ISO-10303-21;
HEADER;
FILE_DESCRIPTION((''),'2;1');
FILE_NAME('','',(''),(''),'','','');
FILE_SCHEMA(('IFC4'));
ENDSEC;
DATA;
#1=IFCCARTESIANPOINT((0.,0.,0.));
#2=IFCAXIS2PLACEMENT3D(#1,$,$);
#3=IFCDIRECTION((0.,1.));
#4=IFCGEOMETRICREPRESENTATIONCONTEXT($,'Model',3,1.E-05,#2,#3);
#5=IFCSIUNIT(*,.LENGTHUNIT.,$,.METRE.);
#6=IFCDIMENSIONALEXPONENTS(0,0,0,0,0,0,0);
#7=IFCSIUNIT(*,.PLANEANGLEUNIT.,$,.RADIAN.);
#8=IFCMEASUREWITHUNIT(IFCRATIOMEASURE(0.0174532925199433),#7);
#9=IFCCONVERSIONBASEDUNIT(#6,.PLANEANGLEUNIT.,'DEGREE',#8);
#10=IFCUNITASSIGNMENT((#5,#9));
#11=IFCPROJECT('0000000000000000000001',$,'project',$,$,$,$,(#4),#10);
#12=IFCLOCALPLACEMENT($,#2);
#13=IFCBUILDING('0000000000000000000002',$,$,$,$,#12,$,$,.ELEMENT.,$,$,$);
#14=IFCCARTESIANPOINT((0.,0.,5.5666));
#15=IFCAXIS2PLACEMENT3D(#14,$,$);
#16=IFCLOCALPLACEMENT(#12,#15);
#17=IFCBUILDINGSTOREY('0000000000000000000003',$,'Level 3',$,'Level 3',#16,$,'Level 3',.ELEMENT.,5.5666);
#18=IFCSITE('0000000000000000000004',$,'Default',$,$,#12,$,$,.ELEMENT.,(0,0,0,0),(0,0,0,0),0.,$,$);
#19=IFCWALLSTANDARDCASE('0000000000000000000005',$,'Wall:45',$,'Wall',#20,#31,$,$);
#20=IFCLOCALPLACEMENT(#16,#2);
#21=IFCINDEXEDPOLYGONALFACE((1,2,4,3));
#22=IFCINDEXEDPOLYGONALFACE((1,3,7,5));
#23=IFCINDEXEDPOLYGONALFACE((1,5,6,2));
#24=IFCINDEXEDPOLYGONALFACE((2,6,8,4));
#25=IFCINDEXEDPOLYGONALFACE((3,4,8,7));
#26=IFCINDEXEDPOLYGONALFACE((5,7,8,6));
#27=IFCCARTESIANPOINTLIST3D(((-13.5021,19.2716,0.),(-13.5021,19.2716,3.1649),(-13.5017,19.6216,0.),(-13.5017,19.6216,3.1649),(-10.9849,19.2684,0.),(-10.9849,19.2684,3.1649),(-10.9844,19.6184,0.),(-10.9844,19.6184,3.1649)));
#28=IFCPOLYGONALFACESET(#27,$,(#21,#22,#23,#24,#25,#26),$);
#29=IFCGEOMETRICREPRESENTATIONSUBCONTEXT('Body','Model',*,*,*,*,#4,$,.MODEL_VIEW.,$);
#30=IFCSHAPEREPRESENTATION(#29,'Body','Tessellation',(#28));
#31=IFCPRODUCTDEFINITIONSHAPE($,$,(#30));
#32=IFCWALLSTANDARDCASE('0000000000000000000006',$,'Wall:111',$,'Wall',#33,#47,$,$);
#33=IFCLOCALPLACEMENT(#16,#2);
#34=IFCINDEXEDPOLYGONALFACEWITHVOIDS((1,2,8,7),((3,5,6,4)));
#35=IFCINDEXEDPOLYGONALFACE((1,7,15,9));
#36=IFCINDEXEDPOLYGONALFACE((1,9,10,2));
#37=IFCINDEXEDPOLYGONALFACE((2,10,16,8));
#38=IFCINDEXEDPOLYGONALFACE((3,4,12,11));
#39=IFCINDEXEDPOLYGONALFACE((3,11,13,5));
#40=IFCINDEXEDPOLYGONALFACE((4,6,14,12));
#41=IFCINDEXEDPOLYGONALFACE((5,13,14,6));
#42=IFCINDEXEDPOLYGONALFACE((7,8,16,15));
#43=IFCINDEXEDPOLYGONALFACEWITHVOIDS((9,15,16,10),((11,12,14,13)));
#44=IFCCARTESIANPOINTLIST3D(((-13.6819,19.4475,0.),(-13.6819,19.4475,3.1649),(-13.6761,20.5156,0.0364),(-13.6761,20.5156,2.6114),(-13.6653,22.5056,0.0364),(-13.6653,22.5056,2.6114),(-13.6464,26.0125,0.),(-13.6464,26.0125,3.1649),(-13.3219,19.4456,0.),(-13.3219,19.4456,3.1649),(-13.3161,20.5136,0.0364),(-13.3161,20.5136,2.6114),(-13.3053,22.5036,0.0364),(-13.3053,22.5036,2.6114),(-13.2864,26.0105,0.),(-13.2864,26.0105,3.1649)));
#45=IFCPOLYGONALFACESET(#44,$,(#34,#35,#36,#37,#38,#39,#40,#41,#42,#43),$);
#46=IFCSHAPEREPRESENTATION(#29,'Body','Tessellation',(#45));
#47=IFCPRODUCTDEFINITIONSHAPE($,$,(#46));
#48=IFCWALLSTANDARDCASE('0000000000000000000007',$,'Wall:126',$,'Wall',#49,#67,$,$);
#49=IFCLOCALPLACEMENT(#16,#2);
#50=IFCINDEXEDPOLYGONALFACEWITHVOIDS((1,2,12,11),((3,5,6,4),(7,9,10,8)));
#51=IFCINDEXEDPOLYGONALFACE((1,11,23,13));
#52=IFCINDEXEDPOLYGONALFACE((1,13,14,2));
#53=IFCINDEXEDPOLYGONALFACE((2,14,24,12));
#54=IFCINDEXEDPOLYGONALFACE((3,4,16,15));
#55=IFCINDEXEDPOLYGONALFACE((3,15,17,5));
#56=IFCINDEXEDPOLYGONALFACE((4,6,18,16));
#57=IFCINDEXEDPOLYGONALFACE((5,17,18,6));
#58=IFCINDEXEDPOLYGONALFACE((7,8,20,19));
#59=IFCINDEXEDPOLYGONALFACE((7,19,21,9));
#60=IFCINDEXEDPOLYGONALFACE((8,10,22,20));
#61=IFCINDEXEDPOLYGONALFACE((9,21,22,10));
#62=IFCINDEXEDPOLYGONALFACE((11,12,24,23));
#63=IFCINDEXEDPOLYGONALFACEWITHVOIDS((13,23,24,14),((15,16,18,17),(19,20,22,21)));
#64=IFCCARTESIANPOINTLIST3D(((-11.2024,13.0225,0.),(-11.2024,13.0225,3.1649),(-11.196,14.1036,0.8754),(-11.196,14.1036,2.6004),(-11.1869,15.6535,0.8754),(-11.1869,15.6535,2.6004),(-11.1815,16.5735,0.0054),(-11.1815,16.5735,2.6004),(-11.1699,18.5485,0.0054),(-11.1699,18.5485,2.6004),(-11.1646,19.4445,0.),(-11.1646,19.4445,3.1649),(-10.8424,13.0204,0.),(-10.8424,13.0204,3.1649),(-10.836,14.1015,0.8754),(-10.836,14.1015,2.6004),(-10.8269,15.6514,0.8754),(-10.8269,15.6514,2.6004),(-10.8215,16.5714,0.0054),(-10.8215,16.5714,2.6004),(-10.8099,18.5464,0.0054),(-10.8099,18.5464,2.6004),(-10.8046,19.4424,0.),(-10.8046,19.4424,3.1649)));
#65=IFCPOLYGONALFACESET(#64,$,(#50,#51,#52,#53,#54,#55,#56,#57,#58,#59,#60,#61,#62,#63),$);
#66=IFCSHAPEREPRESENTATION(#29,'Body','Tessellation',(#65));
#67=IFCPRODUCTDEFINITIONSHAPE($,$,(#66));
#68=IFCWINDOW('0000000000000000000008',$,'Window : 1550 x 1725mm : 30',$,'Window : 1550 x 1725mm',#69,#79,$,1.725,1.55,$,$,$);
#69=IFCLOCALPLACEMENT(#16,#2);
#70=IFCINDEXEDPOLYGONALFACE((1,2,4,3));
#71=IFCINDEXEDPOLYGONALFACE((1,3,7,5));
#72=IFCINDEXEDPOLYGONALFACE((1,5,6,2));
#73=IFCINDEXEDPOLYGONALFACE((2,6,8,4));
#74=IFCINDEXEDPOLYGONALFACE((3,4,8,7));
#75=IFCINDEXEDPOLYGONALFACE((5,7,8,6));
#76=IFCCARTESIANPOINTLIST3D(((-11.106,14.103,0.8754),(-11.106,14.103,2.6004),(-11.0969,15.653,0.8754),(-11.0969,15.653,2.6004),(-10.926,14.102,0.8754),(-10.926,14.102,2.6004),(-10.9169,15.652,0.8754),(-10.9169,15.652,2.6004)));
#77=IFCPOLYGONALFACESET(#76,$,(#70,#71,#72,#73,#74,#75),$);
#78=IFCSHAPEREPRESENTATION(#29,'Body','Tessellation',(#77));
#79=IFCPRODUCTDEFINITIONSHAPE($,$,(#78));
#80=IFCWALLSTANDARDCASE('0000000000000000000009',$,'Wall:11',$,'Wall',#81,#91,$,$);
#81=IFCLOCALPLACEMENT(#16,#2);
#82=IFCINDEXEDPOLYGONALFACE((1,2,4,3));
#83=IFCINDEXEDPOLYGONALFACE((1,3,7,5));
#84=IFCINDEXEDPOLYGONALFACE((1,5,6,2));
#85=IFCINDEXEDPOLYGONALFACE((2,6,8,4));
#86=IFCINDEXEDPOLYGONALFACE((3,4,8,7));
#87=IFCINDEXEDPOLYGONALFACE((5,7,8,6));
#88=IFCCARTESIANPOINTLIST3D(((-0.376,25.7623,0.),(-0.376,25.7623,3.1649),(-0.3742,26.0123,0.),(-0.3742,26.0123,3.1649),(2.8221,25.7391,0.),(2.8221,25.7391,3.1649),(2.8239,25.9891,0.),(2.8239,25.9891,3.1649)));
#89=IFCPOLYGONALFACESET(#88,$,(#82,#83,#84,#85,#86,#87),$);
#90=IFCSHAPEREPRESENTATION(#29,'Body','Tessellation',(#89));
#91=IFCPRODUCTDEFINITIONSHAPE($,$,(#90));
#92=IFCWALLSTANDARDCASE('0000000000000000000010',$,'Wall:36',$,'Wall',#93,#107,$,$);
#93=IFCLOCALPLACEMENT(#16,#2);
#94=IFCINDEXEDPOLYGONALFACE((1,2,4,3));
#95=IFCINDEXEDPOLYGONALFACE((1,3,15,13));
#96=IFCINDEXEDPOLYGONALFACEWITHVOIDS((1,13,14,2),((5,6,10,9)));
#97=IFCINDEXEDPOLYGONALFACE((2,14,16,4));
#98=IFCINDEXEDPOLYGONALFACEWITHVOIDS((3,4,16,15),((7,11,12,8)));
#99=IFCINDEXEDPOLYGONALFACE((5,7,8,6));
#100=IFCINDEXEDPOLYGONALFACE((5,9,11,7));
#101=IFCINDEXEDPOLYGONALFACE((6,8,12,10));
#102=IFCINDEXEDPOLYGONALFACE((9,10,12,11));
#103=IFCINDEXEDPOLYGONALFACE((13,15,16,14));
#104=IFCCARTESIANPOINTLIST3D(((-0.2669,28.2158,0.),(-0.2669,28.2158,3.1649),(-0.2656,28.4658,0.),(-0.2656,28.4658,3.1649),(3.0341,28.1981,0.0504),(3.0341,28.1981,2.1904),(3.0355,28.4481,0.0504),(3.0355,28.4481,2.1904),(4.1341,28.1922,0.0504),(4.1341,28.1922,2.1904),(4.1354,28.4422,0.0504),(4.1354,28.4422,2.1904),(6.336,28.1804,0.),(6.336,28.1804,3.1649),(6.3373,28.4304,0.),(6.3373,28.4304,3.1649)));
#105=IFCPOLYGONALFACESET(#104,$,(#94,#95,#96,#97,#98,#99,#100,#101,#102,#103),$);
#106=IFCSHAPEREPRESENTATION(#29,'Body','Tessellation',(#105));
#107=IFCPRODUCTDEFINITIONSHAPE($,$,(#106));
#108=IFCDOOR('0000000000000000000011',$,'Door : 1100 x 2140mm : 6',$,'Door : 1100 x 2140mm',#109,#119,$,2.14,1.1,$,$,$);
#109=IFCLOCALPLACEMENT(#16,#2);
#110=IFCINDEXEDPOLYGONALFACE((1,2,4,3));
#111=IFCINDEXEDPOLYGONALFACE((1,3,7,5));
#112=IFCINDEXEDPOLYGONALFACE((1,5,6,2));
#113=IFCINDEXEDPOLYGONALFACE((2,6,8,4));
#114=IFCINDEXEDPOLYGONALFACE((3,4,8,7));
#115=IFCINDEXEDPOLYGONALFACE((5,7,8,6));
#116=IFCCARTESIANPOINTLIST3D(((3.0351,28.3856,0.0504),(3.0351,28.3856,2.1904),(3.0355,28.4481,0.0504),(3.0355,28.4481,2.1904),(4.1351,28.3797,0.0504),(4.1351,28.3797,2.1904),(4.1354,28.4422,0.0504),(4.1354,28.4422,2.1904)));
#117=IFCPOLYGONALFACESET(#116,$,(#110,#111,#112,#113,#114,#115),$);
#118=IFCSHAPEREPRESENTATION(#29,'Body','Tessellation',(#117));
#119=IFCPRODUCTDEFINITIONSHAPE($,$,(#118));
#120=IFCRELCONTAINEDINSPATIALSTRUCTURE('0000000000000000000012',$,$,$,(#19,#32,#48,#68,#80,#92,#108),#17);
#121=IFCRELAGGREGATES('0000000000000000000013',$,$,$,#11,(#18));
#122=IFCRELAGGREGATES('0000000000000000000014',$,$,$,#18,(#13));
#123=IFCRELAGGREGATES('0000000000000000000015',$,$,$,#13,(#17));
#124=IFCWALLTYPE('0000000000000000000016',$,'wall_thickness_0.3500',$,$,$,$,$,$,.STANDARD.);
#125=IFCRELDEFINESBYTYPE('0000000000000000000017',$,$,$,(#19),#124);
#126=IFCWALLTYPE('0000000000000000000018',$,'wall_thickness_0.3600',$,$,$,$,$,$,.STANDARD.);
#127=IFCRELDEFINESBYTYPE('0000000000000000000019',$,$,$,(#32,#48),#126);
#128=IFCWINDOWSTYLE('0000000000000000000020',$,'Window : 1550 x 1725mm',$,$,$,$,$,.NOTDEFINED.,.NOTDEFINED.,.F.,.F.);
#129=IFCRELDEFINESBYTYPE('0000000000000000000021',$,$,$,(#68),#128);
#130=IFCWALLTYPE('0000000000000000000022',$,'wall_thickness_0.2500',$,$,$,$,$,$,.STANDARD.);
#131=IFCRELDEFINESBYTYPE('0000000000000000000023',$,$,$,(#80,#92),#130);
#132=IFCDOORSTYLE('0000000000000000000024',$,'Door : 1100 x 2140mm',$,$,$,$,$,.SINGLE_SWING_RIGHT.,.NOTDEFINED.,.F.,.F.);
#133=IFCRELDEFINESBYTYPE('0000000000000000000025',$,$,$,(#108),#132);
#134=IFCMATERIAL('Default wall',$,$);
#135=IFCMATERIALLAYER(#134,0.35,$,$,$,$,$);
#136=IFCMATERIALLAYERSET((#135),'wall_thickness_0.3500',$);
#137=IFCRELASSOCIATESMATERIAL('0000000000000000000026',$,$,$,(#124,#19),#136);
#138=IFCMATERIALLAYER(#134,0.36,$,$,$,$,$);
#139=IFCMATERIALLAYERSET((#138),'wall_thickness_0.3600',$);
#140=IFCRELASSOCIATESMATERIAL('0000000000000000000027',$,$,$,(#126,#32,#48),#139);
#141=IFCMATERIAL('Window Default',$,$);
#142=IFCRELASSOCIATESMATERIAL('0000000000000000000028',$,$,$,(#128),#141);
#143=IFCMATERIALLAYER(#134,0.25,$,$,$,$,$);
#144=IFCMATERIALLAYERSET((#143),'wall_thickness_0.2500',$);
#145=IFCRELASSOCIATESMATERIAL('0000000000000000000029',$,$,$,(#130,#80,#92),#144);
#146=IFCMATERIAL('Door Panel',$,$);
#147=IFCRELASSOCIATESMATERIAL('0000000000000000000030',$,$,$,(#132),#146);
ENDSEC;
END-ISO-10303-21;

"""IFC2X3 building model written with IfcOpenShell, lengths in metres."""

from ifc_helpers import new_model, entity, si_unit, converted_unit, direction, frame, frame_2d, origin, origin_2d_with_axis, place, context, subcontext, project, spatial, polyline, rectangle, outline, extrude, source, transform, mapped, material, layer, layer_set, layer_usage, type_object, type_shapes, element, fill, save


model = new_model("IFC2X3")

# Units and contexts
model_context = context("Model", 3, precision=1e-05, world=origin(), true_north=direction((0.0, 1.0)))
body_context = subcontext(model_context, "Body", "Model", "MODEL_VIEW")
ifc_project = project(units=[si_unit("LENGTHUNIT", "METRE"), converted_unit("PLANEANGLEUNIT", "DEGREE", entity("IfcRatioMeasure", 0.0174532925199433), si_unit("PLANEANGLEUNIT", "RADIAN"), dimensions=[0, 0, 0, 0, 0, 0, 0])], contexts=[model_context])

# Site, building, storey
placement_1 = place(None, origin())
site = spatial("IfcSite", under=ifc_project, at=placement_1, Name="Default", CompositionType="ELEMENT", RefLatitude=(0, 0, 0, 0), RefLongitude=(0, 0, 0, 0), RefElevation=0.0)
building = spatial("IfcBuilding", under=site, at=placement_1, CompositionType="ELEMENT")
storey_placement = place(placement_1, frame((0.0, 0.0, 5.5666)))
storey = spatial("IfcBuildingStorey", under=building, at=storey_placement, Name="Level 3", ObjectType="Level 3", LongName="Level 3", CompositionType="ELEMENT", Elevation=5.5666)

# Wall
ifc_material_1 = material(Name="Default wall")
ifc_layer_1 = layer(ifc_material_1, 0.35)
ifc_layer_set_1 = layer_set([ifc_layer_1], Name="wall_thickness_0.3500")
ifc_layer_usage_1 = layer_usage(ifc_layer_set_1, "AXIS2", "POSITIVE", -0.175)
wall_type_1 = type_object("IfcWallType", Name="wall_thickness_0.3500", PredefinedType="STANDARD", material=ifc_layer_set_1)
wall_1_placement = place(storey_placement, frame((-13.5019, 19.4466, 0.0), z_axis=(0.0, 0.0, 1.0), x_axis=(0.999999, -0.001234, 0.0)))
element("IfcWallStandardCase", 1, at=wall_1_placement, inside=storey, type_object=wall_type_1, material=ifc_layer_usage_1, Name="Wall:45", ObjectType="Wall", context=body_context, shape_type="SweptSolid", body=[
    extrude(outline(polyline([(2.5172, -0.175), (2.5172, 0.175), (0.0, 0.175), (0.0, -0.175), (2.5172, -0.175)])), origin(), (0.0, 0.0, 1.0), 3.1649),
])

# Wall, opening
ifc_layer_2 = layer(ifc_material_1, 0.36)
ifc_layer_set_2 = layer_set([ifc_layer_2], Name="wall_thickness_0.3600")
ifc_layer_usage_2 = layer_usage(ifc_layer_set_2, "AXIS2", "POSITIVE", -0.18)
wall_type_2 = type_object("IfcWallType", Name="wall_thickness_0.3600", PredefinedType="STANDARD", material=ifc_layer_set_2)
wall_2_placement = place(storey_placement, frame((-13.4664, 26.0115, 0.0), z_axis=(0.0, 0.0, 1.0), x_axis=(-0.005406, -0.999985, 0.0)))
wall_2 = element("IfcWallStandardCase", 2, at=wall_2_placement, inside=storey, type_object=wall_type_2, material=ifc_layer_usage_2, Name="Wall:111", ObjectType="Wall", context=body_context, shape_type="SweptSolid", body=[
    extrude(outline(polyline([(6.565, -0.18), (6.565, 0.18), (0.0, 0.18), (0.0, -0.18), (6.565, -0.18)])), origin(), (0.0, 0.0, 1.0), 3.1649),
])
opening_1_placement = place(wall_2_placement, frame((3.507, -0.18, 0.0364)))
element("IfcOpeningElement", 3, at=opening_1_placement, cuts=wall_2, ObjectType="Opening", context=body_context, shape_type="SweptSolid", body=[
    extrude(rectangle(XDim=1.99, YDim=2.575, at=frame_2d((1.2875, 0.995), x_axis=(0.0, 1.0))), frame((0.0, 0.0, 0.0), z_axis=(0.0, 1.0, 0.0), x_axis=(0.0, 0.0, 1.0)), (0.0, 0.0, 1.0), 0.36),
])

# Wall, openings, window
wall_3_placement = place(storey_placement, frame((-10.9846, 19.4435, 0.0), z_axis=(0.0, 0.0, 1.0), x_axis=(-0.005875, -0.999983, 0.0)))
wall_3 = element("IfcWallStandardCase", 4, at=wall_3_placement, inside=storey, type_object=wall_type_2, material=ifc_layer_usage_2, Name="Wall:126", ObjectType="Wall", context=body_context, shape_type="SweptSolid", body=[
    extrude(outline(polyline([(6.4221, -0.18), (6.4221, 0.18), (0.0, 0.18), (0.0, -0.18), (6.4221, -0.18)])), origin(), (0.0, 0.0, 1.0), 3.1649),
])
opening_2_placement = place(wall_3_placement, frame((0.896, -0.18, 0.0054)))
element("IfcOpeningElement", 5, at=opening_2_placement, cuts=wall_3, ObjectType="Opening", context=body_context, shape_type="SweptSolid", body=[
    extrude(rectangle(XDim=1.975, YDim=2.595, at=frame_2d((1.2975, 0.9875), x_axis=(0.0, 1.0))), frame((0.0, 0.0, 0.0), z_axis=(0.0, 1.0, 0.0), x_axis=(0.0, 0.0, 1.0)), (0.0, 0.0, 1.0), 0.36),
])
opening_3_placement = place(wall_3_placement, frame((3.791, -0.18, 0.8754)))
opening_3 = element("IfcOpeningElement", 6, at=opening_3_placement, cuts=wall_3, ObjectType="Opening", context=body_context, shape_type="SweptSolid", body=[
    extrude(rectangle(XDim=1.55, YDim=1.725, at=frame_2d((0.8625, 0.775), x_axis=(0.0, 1.0))), frame((0.0, 0.0, 0.0), z_axis=(0.0, 1.0, 0.0), x_axis=(0.0, 0.0, 1.0)), (0.0, 0.0, 1.0), 0.36),
])
ifc_material_2 = material(Name="Window Default")
window_style_1 = type_object("IfcWindowStyle", Name="Window : 1550 x 1725mm", ConstructionType="NOTDEFINED", OperationType="NOTDEFINED", ParameterTakesPrecedence=False, Sizeable=False, material=ifc_material_2)
shared_shape_1 = source(origin(), body_context, "Body", "SweptSolid", [
    extrude(rectangle(XDim=0.18, YDim=1.55, at=origin_2d_with_axis()), frame((0.775, 0.18, 0.0), z_axis=(0.0, 0.0, 1.0), x_axis=(0.0, 1.0, 0.0)), (0.0, 0.0, 1.0), 1.725),
])
type_shapes(window_style_1, [shared_shape_1])
window_1_placement = place(opening_3_placement, origin())
window_1 = element("IfcWindow", 7, at=window_1_placement, inside=storey, type_object=window_style_1, Name="Window : 1550 x 1725mm : 30", ObjectType="Window : 1550 x 1725mm", OverallHeight=1.725, OverallWidth=1.55, context=body_context, shape_type="MappedRepresentation", body=[
    mapped(shared_shape_1, transform((0.0, 0.0, 0.0), scale=1.0)),
])
fill(opening_3, window_1)

# Wall
ifc_layer_3 = layer(ifc_material_1, 0.25)
ifc_layer_set_3 = layer_set([ifc_layer_3], Name="wall_thickness_0.2500")
ifc_layer_usage_3 = layer_usage(ifc_layer_set_3, "AXIS2", "POSITIVE", -0.125)
wall_type_3 = type_object("IfcWallType", Name="wall_thickness_0.2500", PredefinedType="STANDARD", material=ifc_layer_set_3)
wall_4_placement = place(storey_placement, frame((-0.3751, 25.8873, 0.0), z_axis=(0.0, 0.0, 1.0), x_axis=(0.999974, -0.00727, 0.0)))
element("IfcWallStandardCase", 8, at=wall_4_placement, inside=storey, type_object=wall_type_3, material=ifc_layer_usage_3, Name="Wall:11", ObjectType="Wall", context=body_context, shape_type="SweptSolid", body=[
    extrude(outline(polyline([(3.1982, -0.125), (3.1982, 0.125), (0.0, 0.125), (0.0, -0.125), (3.1982, -0.125)])), origin(), (0.0, 0.0, 1.0), 3.1649),
])

# Wall, opening, door
wall_5_placement = place(storey_placement, frame((-0.2662, 28.3408, 0.0), z_axis=(0.0, 0.0, 1.0), x_axis=(0.999986, -0.005351, 0.0)))
wall_5 = element("IfcWallStandardCase", 9, at=wall_5_placement, inside=storey, type_object=wall_type_3, material=ifc_layer_usage_3, Name="Wall:36", ObjectType="Wall", context=body_context, shape_type="SweptSolid", body=[
    extrude(outline(polyline([(6.603, -0.125), (6.603, 0.125), (0.0, 0.125), (0.0, -0.125), (6.603, -0.125)])), origin(), (0.0, 0.0, 1.0), 3.1649),
])
opening_4_placement = place(wall_5_placement, frame((3.3011, -0.125, 0.0504)))
opening_4 = element("IfcOpeningElement", 10, at=opening_4_placement, cuts=wall_5, ObjectType="Opening", context=body_context, shape_type="SweptSolid", body=[
    extrude(rectangle(XDim=1.1, YDim=2.14, at=frame_2d((1.07, 0.55), x_axis=(0.0, 1.0))), frame((0.0, 0.0, 0.0), z_axis=(0.0, 1.0, 0.0), x_axis=(0.0, 0.0, 1.0)), (0.0, 0.0, 1.0), 0.25),
])
ifc_material_3 = material(Name="Door Panel")
door_style = type_object("IfcDoorStyle", Name="Door : 1100 x 2140mm", ConstructionType="NOTDEFINED", OperationType="SINGLE_SWING_RIGHT", ParameterTakesPrecedence=False, Sizeable=False, material=ifc_material_3)
shared_shape_2 = source(origin(), body_context, "Body", "SweptSolid", [
    extrude(rectangle(XDim=0.0625, YDim=1.1, at=origin_2d_with_axis()), frame((0.55, 0.2188, 0.0), z_axis=(0.0, 0.0, 1.0), x_axis=(0.0, 1.0, 0.0)), (0.0, 0.0, 1.0), 2.14),
])
type_shapes(door_style, [shared_shape_2])
door_placement = place(opening_4_placement, origin())
door = element("IfcDoor", 11, at=door_placement, inside=storey, type_object=door_style, Name="Door : 1100 x 2140mm : 6", ObjectType="Door : 1100 x 2140mm", OverallHeight=2.14, OverallWidth=1.1, context=body_context, shape_type="MappedRepresentation", body=[
    mapped(shared_shape_2, transform((0.0, 0.0, 0.0), scale=1.0)),
])
fill(opening_4, door)

save(model, "model.ifc")
